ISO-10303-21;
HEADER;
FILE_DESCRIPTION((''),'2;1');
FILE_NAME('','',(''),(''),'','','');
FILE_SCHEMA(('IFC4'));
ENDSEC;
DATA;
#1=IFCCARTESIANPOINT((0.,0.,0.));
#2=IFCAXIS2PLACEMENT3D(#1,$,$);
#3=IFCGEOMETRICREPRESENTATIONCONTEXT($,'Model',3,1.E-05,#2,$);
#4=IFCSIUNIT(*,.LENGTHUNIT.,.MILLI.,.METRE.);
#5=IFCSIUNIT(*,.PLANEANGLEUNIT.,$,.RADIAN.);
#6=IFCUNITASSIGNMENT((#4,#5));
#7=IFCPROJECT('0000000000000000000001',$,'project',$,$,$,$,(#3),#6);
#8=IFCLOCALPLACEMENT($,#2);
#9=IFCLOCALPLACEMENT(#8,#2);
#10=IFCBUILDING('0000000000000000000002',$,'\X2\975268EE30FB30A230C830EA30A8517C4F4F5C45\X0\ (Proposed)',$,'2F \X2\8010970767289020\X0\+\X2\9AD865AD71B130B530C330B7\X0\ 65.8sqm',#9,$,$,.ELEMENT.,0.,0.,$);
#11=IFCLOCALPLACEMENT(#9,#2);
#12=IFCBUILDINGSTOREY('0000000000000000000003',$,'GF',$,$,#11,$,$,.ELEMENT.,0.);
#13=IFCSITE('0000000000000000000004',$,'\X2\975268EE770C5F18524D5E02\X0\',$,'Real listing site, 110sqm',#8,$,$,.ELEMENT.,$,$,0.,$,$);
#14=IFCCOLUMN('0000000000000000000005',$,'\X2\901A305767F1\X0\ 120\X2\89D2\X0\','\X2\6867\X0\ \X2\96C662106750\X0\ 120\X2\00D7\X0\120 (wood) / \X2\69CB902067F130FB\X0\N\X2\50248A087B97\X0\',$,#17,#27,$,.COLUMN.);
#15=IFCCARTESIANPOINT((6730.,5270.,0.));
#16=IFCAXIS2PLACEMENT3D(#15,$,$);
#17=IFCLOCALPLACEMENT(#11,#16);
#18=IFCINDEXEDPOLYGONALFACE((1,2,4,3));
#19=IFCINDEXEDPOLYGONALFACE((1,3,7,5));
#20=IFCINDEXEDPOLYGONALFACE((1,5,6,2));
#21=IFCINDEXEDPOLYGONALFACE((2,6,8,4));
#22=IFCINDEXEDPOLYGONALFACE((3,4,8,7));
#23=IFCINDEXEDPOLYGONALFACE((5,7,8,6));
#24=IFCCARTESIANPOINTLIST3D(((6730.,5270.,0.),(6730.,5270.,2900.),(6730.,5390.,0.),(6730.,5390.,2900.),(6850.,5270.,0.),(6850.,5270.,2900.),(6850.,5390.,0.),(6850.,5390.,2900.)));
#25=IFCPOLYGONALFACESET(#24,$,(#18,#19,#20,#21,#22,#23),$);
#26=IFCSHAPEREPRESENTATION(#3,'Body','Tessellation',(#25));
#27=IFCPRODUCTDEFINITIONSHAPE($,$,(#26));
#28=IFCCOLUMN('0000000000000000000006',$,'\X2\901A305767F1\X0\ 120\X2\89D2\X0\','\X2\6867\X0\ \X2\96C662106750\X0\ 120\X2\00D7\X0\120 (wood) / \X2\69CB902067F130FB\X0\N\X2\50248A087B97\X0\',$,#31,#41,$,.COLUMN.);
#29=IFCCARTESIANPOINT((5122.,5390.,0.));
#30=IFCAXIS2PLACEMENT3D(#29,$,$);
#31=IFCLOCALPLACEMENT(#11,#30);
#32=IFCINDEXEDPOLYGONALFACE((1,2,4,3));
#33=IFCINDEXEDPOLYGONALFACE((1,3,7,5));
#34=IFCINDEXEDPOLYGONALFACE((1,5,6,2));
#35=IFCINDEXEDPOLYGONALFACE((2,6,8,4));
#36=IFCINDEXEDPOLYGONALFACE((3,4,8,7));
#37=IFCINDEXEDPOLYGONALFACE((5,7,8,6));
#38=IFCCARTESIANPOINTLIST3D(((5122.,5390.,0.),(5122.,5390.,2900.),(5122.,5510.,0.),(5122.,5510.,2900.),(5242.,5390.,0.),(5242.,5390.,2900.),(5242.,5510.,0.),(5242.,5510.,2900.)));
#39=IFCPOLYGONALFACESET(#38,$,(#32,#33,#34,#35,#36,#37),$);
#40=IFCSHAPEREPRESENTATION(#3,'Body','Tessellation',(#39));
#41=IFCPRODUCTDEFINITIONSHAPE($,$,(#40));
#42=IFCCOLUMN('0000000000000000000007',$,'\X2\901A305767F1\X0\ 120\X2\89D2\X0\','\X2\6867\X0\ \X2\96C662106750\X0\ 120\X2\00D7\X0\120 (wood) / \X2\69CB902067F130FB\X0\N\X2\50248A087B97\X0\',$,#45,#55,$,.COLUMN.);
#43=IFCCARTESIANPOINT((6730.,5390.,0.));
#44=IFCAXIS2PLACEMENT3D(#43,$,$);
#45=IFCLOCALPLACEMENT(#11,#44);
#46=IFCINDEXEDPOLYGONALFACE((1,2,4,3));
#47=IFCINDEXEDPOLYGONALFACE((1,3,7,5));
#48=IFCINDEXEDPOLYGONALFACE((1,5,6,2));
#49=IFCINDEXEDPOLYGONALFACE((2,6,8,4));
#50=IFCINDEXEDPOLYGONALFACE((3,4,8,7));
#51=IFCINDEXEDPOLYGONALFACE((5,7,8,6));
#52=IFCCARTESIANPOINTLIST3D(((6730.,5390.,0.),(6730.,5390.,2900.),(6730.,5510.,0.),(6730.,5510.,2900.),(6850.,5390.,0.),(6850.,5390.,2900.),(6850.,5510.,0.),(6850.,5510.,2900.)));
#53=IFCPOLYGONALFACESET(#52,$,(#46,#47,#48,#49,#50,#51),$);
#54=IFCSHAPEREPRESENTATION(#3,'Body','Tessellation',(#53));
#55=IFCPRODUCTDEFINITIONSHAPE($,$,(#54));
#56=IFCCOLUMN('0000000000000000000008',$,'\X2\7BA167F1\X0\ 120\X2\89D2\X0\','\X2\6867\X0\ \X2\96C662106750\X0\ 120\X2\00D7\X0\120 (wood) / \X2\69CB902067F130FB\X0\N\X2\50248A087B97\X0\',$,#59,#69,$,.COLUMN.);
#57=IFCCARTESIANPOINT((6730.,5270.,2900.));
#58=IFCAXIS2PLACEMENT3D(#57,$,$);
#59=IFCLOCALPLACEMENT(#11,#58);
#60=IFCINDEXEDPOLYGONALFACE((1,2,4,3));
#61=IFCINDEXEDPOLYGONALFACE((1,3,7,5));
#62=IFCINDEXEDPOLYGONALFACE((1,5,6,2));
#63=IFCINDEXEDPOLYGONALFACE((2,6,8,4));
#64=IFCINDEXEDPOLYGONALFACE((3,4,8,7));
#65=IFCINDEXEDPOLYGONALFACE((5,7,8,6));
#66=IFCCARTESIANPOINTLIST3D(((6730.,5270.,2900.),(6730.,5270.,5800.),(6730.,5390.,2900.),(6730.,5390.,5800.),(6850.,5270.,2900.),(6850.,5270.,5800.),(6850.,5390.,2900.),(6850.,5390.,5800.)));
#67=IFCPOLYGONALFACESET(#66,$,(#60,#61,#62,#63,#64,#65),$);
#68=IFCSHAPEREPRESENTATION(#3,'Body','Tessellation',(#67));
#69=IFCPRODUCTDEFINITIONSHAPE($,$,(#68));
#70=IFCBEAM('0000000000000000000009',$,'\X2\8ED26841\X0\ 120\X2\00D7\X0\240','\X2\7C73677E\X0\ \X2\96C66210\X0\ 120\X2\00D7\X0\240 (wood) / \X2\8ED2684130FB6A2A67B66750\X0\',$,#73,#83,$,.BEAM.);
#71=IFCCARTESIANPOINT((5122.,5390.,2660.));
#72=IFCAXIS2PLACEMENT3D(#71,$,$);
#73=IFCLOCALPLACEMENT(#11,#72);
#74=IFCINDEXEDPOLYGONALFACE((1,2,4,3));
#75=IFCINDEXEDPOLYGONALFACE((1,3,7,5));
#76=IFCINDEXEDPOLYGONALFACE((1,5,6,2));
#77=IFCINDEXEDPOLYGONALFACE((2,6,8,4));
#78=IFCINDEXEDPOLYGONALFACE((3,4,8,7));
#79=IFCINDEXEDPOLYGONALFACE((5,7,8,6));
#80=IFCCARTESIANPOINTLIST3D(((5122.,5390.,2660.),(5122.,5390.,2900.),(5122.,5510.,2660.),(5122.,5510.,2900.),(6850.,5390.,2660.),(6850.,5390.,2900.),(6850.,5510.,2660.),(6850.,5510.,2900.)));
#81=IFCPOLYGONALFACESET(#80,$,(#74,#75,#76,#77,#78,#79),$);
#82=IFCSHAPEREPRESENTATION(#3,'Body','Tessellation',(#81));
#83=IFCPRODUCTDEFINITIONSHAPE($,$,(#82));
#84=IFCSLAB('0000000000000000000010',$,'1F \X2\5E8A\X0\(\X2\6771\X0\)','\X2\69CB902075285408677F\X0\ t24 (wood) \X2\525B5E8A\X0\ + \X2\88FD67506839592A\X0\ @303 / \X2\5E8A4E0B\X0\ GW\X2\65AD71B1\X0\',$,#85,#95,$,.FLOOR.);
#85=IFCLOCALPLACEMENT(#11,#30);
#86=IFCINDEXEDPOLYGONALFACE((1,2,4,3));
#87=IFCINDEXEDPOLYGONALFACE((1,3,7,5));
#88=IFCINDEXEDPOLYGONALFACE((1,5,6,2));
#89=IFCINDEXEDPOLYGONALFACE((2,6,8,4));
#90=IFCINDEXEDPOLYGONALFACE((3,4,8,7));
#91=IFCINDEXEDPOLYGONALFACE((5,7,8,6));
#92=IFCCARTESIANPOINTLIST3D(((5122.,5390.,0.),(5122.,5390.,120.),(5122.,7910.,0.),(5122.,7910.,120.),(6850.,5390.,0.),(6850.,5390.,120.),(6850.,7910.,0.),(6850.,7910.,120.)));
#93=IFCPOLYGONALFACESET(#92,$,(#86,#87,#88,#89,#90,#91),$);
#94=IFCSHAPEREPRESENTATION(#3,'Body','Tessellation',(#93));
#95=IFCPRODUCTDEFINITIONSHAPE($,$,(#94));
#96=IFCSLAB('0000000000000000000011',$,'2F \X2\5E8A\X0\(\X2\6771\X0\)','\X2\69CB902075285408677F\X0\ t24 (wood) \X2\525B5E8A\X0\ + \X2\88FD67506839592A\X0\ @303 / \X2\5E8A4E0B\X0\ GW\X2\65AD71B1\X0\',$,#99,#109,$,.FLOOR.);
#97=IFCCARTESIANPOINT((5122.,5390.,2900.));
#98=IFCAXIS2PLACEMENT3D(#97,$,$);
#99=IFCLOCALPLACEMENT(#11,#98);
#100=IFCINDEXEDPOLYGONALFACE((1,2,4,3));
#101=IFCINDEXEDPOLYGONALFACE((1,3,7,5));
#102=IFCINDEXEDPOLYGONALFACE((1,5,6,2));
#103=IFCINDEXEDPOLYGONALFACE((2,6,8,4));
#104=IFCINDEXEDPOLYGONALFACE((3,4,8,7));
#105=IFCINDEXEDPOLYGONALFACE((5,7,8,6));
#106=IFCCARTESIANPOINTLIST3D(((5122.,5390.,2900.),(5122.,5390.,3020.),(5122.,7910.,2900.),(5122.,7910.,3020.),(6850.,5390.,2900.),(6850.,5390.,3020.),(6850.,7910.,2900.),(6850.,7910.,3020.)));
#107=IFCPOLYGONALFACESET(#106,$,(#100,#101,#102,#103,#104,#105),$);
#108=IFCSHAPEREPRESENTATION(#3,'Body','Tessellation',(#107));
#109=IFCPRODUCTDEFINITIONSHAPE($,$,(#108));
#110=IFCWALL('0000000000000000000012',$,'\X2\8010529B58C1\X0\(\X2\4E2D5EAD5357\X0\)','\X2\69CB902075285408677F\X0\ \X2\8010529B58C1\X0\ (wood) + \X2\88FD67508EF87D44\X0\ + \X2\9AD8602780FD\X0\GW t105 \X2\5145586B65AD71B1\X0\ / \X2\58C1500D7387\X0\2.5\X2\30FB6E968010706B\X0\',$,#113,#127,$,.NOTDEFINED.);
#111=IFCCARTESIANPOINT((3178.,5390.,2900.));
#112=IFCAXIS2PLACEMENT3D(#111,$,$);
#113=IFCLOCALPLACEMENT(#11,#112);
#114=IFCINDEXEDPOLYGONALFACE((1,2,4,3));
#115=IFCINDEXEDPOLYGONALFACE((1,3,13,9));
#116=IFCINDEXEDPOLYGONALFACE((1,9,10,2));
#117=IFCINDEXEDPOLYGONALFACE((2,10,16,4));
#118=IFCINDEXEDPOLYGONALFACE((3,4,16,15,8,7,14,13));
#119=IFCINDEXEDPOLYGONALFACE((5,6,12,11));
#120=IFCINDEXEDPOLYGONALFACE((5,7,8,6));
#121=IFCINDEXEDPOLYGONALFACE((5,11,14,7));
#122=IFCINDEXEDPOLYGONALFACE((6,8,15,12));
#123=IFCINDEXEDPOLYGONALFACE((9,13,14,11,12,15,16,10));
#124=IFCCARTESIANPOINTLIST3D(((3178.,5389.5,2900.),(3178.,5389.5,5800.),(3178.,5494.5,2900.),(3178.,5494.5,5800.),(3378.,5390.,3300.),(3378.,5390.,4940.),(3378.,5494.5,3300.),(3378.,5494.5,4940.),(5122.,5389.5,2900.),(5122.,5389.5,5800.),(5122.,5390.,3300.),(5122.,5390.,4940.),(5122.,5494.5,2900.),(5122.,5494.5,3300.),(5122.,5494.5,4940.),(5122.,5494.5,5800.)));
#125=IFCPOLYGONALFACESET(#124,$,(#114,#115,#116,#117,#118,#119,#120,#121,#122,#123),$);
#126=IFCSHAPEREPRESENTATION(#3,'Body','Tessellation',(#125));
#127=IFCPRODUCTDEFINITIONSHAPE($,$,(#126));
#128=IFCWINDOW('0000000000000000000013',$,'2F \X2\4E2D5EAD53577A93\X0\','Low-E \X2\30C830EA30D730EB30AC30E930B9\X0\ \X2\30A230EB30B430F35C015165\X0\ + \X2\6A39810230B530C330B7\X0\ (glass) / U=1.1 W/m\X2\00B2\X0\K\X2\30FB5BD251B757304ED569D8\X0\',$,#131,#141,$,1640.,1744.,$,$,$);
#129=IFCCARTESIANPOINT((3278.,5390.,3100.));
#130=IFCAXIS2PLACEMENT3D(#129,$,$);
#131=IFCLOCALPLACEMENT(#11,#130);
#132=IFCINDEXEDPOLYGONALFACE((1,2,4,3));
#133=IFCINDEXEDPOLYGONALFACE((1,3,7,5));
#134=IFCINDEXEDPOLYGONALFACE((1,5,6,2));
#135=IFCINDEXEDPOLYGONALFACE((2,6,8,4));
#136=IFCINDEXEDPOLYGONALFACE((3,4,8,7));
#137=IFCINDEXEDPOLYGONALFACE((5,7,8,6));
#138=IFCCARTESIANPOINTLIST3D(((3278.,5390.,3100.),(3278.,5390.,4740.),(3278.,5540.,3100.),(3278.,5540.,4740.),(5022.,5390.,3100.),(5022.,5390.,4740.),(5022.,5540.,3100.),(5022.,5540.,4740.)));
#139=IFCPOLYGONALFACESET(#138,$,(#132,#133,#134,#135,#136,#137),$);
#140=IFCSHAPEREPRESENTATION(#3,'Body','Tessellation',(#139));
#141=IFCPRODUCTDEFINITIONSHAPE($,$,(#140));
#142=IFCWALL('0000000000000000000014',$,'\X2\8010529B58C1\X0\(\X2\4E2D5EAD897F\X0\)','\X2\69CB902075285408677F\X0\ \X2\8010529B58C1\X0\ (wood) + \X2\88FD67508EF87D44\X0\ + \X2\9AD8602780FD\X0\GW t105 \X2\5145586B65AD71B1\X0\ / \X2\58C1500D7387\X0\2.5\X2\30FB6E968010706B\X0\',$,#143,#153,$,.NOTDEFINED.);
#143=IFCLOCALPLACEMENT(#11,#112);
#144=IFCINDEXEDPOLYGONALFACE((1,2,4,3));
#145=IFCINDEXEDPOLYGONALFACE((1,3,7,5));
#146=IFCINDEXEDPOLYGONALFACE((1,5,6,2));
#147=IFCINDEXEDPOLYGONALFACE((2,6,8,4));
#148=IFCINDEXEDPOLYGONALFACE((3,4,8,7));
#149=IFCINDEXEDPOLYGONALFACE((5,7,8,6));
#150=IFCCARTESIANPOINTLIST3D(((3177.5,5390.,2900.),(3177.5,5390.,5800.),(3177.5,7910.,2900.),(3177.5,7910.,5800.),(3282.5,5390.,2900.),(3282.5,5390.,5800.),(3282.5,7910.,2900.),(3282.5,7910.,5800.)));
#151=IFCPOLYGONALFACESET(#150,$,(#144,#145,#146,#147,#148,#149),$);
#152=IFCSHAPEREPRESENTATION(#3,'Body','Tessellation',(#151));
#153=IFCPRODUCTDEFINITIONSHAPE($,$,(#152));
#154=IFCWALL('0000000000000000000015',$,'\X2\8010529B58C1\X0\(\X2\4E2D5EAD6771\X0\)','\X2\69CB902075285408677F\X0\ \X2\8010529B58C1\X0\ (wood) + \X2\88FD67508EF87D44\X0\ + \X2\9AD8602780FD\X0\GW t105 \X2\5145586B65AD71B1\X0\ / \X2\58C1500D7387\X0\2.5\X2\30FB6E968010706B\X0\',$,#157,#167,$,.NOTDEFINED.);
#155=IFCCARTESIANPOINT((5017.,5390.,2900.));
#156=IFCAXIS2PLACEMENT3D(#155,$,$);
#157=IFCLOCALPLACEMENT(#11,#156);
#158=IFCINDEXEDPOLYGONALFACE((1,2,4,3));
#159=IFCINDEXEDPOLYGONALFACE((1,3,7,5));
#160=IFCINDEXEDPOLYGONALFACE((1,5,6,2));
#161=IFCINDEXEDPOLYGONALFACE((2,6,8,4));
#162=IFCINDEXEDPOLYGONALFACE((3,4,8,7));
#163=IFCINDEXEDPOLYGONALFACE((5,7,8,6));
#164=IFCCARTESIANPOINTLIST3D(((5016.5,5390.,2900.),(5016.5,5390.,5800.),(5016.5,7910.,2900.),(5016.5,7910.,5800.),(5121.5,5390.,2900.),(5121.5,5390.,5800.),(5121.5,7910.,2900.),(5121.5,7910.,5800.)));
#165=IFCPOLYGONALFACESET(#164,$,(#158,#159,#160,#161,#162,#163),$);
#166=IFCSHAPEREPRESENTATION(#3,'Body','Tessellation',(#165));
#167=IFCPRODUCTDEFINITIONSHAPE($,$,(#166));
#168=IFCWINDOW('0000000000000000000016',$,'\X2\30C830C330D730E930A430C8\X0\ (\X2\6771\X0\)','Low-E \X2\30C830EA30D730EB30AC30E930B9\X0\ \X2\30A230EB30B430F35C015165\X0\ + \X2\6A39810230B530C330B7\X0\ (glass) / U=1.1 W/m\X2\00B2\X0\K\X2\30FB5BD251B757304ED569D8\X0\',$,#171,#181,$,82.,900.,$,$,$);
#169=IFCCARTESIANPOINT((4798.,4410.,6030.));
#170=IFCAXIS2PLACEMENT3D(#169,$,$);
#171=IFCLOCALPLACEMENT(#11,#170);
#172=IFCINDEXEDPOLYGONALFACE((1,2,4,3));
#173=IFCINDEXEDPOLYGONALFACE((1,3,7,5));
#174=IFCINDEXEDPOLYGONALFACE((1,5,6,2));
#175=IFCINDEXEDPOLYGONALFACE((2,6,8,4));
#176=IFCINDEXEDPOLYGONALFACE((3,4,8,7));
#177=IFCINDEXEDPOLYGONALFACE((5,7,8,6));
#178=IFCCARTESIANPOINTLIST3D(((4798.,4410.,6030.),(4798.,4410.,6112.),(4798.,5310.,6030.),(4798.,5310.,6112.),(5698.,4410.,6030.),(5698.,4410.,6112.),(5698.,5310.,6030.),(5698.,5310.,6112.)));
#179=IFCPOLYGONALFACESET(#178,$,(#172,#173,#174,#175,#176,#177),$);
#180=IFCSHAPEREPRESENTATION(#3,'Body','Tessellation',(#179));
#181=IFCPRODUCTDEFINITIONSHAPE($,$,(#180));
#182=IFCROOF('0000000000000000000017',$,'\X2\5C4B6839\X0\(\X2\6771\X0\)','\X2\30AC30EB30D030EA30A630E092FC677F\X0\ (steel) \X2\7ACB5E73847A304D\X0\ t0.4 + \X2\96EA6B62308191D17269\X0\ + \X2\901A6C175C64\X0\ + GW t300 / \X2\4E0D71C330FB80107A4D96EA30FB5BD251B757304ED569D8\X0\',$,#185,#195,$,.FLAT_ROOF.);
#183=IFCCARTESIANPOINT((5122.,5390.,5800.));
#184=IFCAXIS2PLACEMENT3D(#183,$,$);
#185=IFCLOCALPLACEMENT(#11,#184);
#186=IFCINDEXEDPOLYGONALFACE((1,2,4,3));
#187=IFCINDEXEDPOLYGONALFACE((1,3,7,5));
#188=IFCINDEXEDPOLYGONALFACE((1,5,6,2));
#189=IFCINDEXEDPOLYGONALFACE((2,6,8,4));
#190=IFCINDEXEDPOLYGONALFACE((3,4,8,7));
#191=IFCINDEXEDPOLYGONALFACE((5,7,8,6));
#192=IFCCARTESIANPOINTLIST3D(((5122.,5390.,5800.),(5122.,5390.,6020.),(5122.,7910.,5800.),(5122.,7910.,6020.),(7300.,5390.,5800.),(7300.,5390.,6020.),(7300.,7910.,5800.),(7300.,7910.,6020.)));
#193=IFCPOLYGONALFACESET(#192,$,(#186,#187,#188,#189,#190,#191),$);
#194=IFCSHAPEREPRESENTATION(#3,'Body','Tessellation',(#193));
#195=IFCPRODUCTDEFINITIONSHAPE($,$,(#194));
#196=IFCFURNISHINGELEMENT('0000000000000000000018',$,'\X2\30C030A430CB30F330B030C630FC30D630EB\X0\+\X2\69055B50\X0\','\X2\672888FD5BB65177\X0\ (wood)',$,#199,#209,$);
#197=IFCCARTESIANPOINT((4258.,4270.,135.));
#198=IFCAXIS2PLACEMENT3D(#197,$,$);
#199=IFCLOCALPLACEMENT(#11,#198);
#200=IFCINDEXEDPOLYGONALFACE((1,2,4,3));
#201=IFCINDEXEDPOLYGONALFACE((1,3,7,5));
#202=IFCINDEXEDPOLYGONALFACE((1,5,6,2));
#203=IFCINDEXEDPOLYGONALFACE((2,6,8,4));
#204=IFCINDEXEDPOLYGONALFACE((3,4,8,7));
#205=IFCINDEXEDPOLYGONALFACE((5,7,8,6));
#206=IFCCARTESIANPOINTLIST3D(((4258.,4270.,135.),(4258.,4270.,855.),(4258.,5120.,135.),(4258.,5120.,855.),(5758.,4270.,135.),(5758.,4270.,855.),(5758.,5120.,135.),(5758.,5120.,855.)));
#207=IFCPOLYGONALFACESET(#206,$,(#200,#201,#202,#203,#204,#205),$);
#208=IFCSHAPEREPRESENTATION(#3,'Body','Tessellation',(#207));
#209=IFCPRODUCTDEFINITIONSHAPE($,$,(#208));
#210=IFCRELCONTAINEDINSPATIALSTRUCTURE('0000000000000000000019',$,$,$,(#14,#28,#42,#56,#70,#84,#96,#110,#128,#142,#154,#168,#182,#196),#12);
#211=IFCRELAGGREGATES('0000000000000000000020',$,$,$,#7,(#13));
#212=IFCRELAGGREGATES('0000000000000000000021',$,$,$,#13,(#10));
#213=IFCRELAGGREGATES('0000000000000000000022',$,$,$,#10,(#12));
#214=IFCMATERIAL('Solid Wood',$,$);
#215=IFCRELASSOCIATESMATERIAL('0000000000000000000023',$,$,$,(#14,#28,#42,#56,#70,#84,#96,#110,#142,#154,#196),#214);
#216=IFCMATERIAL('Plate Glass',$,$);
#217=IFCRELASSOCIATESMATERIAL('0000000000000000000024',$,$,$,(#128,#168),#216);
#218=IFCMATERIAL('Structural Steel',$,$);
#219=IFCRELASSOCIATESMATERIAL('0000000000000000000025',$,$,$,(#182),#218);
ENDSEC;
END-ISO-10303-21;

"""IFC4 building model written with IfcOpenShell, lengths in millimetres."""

from ifc_helpers import new_model, si_unit, frame, frame_2d, origin, place, context, project, spatial, rectangle, extrude, material, element, fill, save


model = new_model("IFC4")

# Units and contexts
model_context = context("Model", 3, precision=1e-05, world=origin())
ifc_project = project(units=[si_unit("LENGTHUNIT", "METRE", prefix="MILLI"), si_unit("PLANEANGLEUNIT", "RADIAN")], contexts=[model_context])

# Site, building, storey
site_placement = place(None, origin())
site = spatial("IfcSite", under=ifc_project, at=site_placement, Name="青森県弘前市", ObjectType="Real listing site, 110sqm", CompositionType="ELEMENT", RefElevation=0.0)
building_placement = place(site_placement, origin())
building = spatial("IfcBuilding", under=site, at=building_placement, Name="青森・アトリエ兼住居 (Proposed)", ObjectType="2F 耐震木造+高断熱サッシ 65.8sqm", CompositionType="ELEMENT", ElevationOfRefHeight=0.0, ElevationOfTerrain=0.0)
storey_placement = place(building_placement, origin())
storey = spatial("IfcBuildingStorey", under=building, at=storey_placement, Name="GF", CompositionType="ELEMENT", Elevation=0.0)

# Columns
ifc_material_1 = material(Name="Solid Wood")
column_1_placement = place(storey_placement, frame((6730.0, 5270.0, 0.0)))
element("IfcColumn", 1, at=column_1_placement, inside=storey, material=ifc_material_1, Name="通し柱 120角", Description="桧 集成材 120×120 (wood) / 構造柱・N値計算", PredefinedType="COLUMN", context=model_context, shape_type="SweptSolid", body=[
    extrude(rectangle(XDim=120.0, YDim=120.0, at=frame_2d((60.0, 60.0))), frame((6730.0, 5270.0, 0.0)), (0.0, 0.0, 1.0), 2900.0),
])
column_2_placement = place(storey_placement, frame((5122.0, 5390.0, 0.0)))
element("IfcColumn", 2, at=column_2_placement, inside=storey, material=ifc_material_1, Name="通し柱 120角", Description="桧 集成材 120×120 (wood) / 構造柱・N値計算", PredefinedType="COLUMN", context=model_context, shape_type="SweptSolid", body=[
    extrude(rectangle(XDim=120.0, YDim=120.0, at=frame_2d((60.0, 60.0))), frame((5122.0, 5390.0, 0.0)), (0.0, 0.0, 1.0), 2900.0),
])
column_3_placement = place(storey_placement, frame((6730.0, 5390.0, 0.0)))
element("IfcColumn", 3, at=column_3_placement, inside=storey, material=ifc_material_1, Name="通し柱 120角", Description="桧 集成材 120×120 (wood) / 構造柱・N値計算", PredefinedType="COLUMN", context=model_context, shape_type="SweptSolid", body=[
    extrude(rectangle(XDim=120.0, YDim=120.0, at=frame_2d((60.0, 60.0))), frame((6730.0, 5390.0, 0.0)), (0.0, 0.0, 1.0), 2900.0),
])
column_4_placement = place(storey_placement, frame((6730.0, 5270.0, 2900.0)))
element("IfcColumn", 4, at=column_4_placement, inside=storey, material=ifc_material_1, Name="管柱 120角", Description="桧 集成材 120×120 (wood) / 構造柱・N値計算", PredefinedType="COLUMN", context=model_context, shape_type="SweptSolid", body=[
    extrude(rectangle(XDim=120.0, YDim=120.0, at=frame_2d((60.0, 60.0))), frame((6730.0, 5270.0, 2900.0)), (0.0, 0.0, 1.0), 2900.0),
])

# Beam
beam_1_placement = place(storey_placement, frame((5122.0, 5390.0, 2660.0)))
element("IfcBeam", 5, at=beam_1_placement, inside=storey, material=ifc_material_1, Name="軒桁 120×240", Description="米松 集成 120×240 (wood) / 軒桁・横架材", PredefinedType="BEAM", context=model_context, shape_type="SweptSolid", body=[
    extrude(rectangle(XDim=1728.0, YDim=120.0, at=frame_2d((864.0, 60.0))), frame((5122.0, 5390.0, 2660.0)), (0.0, 0.0, 1.0), 240.0),
])

# Slabs
slab_1_placement = place(storey_placement, frame((5122.0, 5390.0, 0.0)))
element("IfcSlab", 6, at=slab_1_placement, inside=storey, material=ifc_material_1, Name="1F 床(東)", Description="構造用合板 t24 (wood) 剛床 + 製材根太 @303 / 床下 GW断熱", PredefinedType="FLOOR", context=model_context, shape_type="SweptSolid", body=[
    extrude(rectangle(XDim=1728.0, YDim=2520.0, at=frame_2d((864.0, 1260.0))), frame((5122.0, 5390.0, 0.0)), (0.0, 0.0, 1.0), 120.0),
])
slab_2_placement = place(storey_placement, frame((5122.0, 5390.0, 2900.0)))
element("IfcSlab", 7, at=slab_2_placement, inside=storey, material=ifc_material_1, Name="2F 床(東)", Description="構造用合板 t24 (wood) 剛床 + 製材根太 @303 / 床下 GW断熱", PredefinedType="FLOOR", context=model_context, shape_type="SweptSolid", body=[
    extrude(rectangle(XDim=1728.0, YDim=2520.0, at=frame_2d((864.0, 1260.0))), frame((5122.0, 5390.0, 2900.0)), (0.0, 0.0, 1.0), 120.0),
])

# Wall, opening, window
wall_1_placement = place(storey_placement, frame((3178.0, 5390.0, 2900.0)))
wall_1 = element("IfcWall", 8, at=wall_1_placement, inside=storey, material=ifc_material_1, Name="耐力壁(中庭南)", Description="構造用合板 耐力壁 (wood) + 製材軸組 + 高性能GW t105 充填断熱 / 壁倍率2.5・準耐火", PredefinedType="NOTDEFINED", context=model_context, shape_type="SweptSolid", body=[
    extrude(rectangle(XDim=1944.0, YDim=105.0, at=frame_2d((972.0, 52.0))), frame((3178.0, 5390.0, 2900.0)), (0.0, 0.0, 1.0), 2900.0),
])
opening_placement = place(storey_placement, frame((3278.0, 5390.0, 3100.0)))
opening = element("IfcOpeningElement", 9, at=opening_placement, cuts=wall_1, PredefinedType="NOTDEFINED", context=model_context, shape_type="SweptSolid", body=[
    extrude(rectangle(XDim=1744.0, YDim=150.0, at=frame_2d((872.0, 75.0))), frame((3278.0, 5390.0, 3100.0)), (0.0, 0.0, 1.0), 1640.0),
])
ifc_material_2 = material(Name="Plate Glass")
window_1_placement = place(storey_placement, frame((3278.0, 5390.0, 3100.0)))
window_1 = element("IfcWindow", 10, at=window_1_placement, inside=storey, material=ifc_material_2, Name="2F 中庭南窓", Description="Low-E トリプルガラス アルゴン封入 + 樹脂サッシ (glass) / U=1.1 W/m²K・寒冷地仕様", OverallHeight=1640.0, OverallWidth=1744.0, context=model_context, shape_type="SweptSolid", body=[
    extrude(rectangle(XDim=1744.0, YDim=150.0, at=frame_2d((872.0, 75.0))), frame((3278.0, 5390.0, 3100.0)), (0.0, 0.0, 1.0), 1640.0),
])
fill(opening, window_1)

# Walls
wall_2_placement = place(storey_placement, frame((3178.0, 5390.0, 2900.0)))
element("IfcWall", 11, at=wall_2_placement, inside=storey, material=ifc_material_1, Name="耐力壁(中庭西)", Description="構造用合板 耐力壁 (wood) + 製材軸組 + 高性能GW t105 充填断熱 / 壁倍率2.5・準耐火", PredefinedType="NOTDEFINED", context=model_context, shape_type="SweptSolid", body=[
    extrude(rectangle(XDim=105.0, YDim=2520.0, at=frame_2d((52.0, 1260.0))), frame((3178.0, 5390.0, 2900.0)), (0.0, 0.0, 1.0), 2900.0),
])
wall_3_placement = place(storey_placement, frame((5017.0, 5390.0, 2900.0)))
element("IfcWall", 12, at=wall_3_placement, inside=storey, material=ifc_material_1, Name="耐力壁(中庭東)", Description="構造用合板 耐力壁 (wood) + 製材軸組 + 高性能GW t105 充填断熱 / 壁倍率2.5・準耐火", PredefinedType="NOTDEFINED", context=model_context, shape_type="SweptSolid", body=[
    extrude(rectangle(XDim=105.0, YDim=2520.0, at=frame_2d((52.0, 1260.0))), frame((5017.0, 5390.0, 2900.0)), (0.0, 0.0, 1.0), 2900.0),
])

# Window
window_2_placement = place(storey_placement, frame((4798.0, 4410.0, 6030.0)))
element("IfcWindow", 13, at=window_2_placement, inside=storey, material=ifc_material_2, Name="トップライト (東)", Description="Low-E トリプルガラス アルゴン封入 + 樹脂サッシ (glass) / U=1.1 W/m²K・寒冷地仕様", OverallHeight=82.0, OverallWidth=900.0, context=model_context, shape_type="SweptSolid", body=[
    extrude(rectangle(XDim=900.0, YDim=900.0, at=frame_2d((450.0, 450.0))), frame((4798.0, 4410.0, 6030.0)), (0.0, 0.0, 1.0), 82.0),
])

# Roof
ifc_material_3 = material(Name="Structural Steel")
for number, where, name in (
    (14, (5122.0, 5390.0, 5800.0), "屋根(東)"),
):
    element("IfcRoof", number, at=place(storey_placement, frame(where)), inside=storey, material=ifc_material_3, Name=name, Description="ガルバリウム鋼板 (steel) 立平葺き t0.4 + 雪止め金物 + 通気層 + GW t300 / 不燃・耐積雪・寒冷地仕様", PredefinedType="FLAT_ROOF", context=model_context, shape_type="SweptSolid", body=[
        extrude(rectangle(XDim=2178.0, YDim=2520.0, at=frame_2d((1089.0, 1260.0))), frame((5122.0, 5390.0, 5800.0)), (0.0, 0.0, 1.0), 220.0),
    ])

# Furnishing element
furnishing_1_placement = place(storey_placement, frame((4258.0, 4270.0, 135.0)))
element("IfcFurnishingElement", 15, at=furnishing_1_placement, inside=storey, material=ifc_material_1, Name="ダイニングテーブル+椅子", Description="木製家具 (wood)", context=model_context, shape_type="SweptSolid", body=[
    extrude(rectangle(XDim=1500.0, YDim=850.0, at=frame_2d((750.0, 425.0))), frame((4258.0, 4270.0, 135.0)), (0.0, 0.0, 1.0), 720.0),
])

save(model, "model.ifc")
